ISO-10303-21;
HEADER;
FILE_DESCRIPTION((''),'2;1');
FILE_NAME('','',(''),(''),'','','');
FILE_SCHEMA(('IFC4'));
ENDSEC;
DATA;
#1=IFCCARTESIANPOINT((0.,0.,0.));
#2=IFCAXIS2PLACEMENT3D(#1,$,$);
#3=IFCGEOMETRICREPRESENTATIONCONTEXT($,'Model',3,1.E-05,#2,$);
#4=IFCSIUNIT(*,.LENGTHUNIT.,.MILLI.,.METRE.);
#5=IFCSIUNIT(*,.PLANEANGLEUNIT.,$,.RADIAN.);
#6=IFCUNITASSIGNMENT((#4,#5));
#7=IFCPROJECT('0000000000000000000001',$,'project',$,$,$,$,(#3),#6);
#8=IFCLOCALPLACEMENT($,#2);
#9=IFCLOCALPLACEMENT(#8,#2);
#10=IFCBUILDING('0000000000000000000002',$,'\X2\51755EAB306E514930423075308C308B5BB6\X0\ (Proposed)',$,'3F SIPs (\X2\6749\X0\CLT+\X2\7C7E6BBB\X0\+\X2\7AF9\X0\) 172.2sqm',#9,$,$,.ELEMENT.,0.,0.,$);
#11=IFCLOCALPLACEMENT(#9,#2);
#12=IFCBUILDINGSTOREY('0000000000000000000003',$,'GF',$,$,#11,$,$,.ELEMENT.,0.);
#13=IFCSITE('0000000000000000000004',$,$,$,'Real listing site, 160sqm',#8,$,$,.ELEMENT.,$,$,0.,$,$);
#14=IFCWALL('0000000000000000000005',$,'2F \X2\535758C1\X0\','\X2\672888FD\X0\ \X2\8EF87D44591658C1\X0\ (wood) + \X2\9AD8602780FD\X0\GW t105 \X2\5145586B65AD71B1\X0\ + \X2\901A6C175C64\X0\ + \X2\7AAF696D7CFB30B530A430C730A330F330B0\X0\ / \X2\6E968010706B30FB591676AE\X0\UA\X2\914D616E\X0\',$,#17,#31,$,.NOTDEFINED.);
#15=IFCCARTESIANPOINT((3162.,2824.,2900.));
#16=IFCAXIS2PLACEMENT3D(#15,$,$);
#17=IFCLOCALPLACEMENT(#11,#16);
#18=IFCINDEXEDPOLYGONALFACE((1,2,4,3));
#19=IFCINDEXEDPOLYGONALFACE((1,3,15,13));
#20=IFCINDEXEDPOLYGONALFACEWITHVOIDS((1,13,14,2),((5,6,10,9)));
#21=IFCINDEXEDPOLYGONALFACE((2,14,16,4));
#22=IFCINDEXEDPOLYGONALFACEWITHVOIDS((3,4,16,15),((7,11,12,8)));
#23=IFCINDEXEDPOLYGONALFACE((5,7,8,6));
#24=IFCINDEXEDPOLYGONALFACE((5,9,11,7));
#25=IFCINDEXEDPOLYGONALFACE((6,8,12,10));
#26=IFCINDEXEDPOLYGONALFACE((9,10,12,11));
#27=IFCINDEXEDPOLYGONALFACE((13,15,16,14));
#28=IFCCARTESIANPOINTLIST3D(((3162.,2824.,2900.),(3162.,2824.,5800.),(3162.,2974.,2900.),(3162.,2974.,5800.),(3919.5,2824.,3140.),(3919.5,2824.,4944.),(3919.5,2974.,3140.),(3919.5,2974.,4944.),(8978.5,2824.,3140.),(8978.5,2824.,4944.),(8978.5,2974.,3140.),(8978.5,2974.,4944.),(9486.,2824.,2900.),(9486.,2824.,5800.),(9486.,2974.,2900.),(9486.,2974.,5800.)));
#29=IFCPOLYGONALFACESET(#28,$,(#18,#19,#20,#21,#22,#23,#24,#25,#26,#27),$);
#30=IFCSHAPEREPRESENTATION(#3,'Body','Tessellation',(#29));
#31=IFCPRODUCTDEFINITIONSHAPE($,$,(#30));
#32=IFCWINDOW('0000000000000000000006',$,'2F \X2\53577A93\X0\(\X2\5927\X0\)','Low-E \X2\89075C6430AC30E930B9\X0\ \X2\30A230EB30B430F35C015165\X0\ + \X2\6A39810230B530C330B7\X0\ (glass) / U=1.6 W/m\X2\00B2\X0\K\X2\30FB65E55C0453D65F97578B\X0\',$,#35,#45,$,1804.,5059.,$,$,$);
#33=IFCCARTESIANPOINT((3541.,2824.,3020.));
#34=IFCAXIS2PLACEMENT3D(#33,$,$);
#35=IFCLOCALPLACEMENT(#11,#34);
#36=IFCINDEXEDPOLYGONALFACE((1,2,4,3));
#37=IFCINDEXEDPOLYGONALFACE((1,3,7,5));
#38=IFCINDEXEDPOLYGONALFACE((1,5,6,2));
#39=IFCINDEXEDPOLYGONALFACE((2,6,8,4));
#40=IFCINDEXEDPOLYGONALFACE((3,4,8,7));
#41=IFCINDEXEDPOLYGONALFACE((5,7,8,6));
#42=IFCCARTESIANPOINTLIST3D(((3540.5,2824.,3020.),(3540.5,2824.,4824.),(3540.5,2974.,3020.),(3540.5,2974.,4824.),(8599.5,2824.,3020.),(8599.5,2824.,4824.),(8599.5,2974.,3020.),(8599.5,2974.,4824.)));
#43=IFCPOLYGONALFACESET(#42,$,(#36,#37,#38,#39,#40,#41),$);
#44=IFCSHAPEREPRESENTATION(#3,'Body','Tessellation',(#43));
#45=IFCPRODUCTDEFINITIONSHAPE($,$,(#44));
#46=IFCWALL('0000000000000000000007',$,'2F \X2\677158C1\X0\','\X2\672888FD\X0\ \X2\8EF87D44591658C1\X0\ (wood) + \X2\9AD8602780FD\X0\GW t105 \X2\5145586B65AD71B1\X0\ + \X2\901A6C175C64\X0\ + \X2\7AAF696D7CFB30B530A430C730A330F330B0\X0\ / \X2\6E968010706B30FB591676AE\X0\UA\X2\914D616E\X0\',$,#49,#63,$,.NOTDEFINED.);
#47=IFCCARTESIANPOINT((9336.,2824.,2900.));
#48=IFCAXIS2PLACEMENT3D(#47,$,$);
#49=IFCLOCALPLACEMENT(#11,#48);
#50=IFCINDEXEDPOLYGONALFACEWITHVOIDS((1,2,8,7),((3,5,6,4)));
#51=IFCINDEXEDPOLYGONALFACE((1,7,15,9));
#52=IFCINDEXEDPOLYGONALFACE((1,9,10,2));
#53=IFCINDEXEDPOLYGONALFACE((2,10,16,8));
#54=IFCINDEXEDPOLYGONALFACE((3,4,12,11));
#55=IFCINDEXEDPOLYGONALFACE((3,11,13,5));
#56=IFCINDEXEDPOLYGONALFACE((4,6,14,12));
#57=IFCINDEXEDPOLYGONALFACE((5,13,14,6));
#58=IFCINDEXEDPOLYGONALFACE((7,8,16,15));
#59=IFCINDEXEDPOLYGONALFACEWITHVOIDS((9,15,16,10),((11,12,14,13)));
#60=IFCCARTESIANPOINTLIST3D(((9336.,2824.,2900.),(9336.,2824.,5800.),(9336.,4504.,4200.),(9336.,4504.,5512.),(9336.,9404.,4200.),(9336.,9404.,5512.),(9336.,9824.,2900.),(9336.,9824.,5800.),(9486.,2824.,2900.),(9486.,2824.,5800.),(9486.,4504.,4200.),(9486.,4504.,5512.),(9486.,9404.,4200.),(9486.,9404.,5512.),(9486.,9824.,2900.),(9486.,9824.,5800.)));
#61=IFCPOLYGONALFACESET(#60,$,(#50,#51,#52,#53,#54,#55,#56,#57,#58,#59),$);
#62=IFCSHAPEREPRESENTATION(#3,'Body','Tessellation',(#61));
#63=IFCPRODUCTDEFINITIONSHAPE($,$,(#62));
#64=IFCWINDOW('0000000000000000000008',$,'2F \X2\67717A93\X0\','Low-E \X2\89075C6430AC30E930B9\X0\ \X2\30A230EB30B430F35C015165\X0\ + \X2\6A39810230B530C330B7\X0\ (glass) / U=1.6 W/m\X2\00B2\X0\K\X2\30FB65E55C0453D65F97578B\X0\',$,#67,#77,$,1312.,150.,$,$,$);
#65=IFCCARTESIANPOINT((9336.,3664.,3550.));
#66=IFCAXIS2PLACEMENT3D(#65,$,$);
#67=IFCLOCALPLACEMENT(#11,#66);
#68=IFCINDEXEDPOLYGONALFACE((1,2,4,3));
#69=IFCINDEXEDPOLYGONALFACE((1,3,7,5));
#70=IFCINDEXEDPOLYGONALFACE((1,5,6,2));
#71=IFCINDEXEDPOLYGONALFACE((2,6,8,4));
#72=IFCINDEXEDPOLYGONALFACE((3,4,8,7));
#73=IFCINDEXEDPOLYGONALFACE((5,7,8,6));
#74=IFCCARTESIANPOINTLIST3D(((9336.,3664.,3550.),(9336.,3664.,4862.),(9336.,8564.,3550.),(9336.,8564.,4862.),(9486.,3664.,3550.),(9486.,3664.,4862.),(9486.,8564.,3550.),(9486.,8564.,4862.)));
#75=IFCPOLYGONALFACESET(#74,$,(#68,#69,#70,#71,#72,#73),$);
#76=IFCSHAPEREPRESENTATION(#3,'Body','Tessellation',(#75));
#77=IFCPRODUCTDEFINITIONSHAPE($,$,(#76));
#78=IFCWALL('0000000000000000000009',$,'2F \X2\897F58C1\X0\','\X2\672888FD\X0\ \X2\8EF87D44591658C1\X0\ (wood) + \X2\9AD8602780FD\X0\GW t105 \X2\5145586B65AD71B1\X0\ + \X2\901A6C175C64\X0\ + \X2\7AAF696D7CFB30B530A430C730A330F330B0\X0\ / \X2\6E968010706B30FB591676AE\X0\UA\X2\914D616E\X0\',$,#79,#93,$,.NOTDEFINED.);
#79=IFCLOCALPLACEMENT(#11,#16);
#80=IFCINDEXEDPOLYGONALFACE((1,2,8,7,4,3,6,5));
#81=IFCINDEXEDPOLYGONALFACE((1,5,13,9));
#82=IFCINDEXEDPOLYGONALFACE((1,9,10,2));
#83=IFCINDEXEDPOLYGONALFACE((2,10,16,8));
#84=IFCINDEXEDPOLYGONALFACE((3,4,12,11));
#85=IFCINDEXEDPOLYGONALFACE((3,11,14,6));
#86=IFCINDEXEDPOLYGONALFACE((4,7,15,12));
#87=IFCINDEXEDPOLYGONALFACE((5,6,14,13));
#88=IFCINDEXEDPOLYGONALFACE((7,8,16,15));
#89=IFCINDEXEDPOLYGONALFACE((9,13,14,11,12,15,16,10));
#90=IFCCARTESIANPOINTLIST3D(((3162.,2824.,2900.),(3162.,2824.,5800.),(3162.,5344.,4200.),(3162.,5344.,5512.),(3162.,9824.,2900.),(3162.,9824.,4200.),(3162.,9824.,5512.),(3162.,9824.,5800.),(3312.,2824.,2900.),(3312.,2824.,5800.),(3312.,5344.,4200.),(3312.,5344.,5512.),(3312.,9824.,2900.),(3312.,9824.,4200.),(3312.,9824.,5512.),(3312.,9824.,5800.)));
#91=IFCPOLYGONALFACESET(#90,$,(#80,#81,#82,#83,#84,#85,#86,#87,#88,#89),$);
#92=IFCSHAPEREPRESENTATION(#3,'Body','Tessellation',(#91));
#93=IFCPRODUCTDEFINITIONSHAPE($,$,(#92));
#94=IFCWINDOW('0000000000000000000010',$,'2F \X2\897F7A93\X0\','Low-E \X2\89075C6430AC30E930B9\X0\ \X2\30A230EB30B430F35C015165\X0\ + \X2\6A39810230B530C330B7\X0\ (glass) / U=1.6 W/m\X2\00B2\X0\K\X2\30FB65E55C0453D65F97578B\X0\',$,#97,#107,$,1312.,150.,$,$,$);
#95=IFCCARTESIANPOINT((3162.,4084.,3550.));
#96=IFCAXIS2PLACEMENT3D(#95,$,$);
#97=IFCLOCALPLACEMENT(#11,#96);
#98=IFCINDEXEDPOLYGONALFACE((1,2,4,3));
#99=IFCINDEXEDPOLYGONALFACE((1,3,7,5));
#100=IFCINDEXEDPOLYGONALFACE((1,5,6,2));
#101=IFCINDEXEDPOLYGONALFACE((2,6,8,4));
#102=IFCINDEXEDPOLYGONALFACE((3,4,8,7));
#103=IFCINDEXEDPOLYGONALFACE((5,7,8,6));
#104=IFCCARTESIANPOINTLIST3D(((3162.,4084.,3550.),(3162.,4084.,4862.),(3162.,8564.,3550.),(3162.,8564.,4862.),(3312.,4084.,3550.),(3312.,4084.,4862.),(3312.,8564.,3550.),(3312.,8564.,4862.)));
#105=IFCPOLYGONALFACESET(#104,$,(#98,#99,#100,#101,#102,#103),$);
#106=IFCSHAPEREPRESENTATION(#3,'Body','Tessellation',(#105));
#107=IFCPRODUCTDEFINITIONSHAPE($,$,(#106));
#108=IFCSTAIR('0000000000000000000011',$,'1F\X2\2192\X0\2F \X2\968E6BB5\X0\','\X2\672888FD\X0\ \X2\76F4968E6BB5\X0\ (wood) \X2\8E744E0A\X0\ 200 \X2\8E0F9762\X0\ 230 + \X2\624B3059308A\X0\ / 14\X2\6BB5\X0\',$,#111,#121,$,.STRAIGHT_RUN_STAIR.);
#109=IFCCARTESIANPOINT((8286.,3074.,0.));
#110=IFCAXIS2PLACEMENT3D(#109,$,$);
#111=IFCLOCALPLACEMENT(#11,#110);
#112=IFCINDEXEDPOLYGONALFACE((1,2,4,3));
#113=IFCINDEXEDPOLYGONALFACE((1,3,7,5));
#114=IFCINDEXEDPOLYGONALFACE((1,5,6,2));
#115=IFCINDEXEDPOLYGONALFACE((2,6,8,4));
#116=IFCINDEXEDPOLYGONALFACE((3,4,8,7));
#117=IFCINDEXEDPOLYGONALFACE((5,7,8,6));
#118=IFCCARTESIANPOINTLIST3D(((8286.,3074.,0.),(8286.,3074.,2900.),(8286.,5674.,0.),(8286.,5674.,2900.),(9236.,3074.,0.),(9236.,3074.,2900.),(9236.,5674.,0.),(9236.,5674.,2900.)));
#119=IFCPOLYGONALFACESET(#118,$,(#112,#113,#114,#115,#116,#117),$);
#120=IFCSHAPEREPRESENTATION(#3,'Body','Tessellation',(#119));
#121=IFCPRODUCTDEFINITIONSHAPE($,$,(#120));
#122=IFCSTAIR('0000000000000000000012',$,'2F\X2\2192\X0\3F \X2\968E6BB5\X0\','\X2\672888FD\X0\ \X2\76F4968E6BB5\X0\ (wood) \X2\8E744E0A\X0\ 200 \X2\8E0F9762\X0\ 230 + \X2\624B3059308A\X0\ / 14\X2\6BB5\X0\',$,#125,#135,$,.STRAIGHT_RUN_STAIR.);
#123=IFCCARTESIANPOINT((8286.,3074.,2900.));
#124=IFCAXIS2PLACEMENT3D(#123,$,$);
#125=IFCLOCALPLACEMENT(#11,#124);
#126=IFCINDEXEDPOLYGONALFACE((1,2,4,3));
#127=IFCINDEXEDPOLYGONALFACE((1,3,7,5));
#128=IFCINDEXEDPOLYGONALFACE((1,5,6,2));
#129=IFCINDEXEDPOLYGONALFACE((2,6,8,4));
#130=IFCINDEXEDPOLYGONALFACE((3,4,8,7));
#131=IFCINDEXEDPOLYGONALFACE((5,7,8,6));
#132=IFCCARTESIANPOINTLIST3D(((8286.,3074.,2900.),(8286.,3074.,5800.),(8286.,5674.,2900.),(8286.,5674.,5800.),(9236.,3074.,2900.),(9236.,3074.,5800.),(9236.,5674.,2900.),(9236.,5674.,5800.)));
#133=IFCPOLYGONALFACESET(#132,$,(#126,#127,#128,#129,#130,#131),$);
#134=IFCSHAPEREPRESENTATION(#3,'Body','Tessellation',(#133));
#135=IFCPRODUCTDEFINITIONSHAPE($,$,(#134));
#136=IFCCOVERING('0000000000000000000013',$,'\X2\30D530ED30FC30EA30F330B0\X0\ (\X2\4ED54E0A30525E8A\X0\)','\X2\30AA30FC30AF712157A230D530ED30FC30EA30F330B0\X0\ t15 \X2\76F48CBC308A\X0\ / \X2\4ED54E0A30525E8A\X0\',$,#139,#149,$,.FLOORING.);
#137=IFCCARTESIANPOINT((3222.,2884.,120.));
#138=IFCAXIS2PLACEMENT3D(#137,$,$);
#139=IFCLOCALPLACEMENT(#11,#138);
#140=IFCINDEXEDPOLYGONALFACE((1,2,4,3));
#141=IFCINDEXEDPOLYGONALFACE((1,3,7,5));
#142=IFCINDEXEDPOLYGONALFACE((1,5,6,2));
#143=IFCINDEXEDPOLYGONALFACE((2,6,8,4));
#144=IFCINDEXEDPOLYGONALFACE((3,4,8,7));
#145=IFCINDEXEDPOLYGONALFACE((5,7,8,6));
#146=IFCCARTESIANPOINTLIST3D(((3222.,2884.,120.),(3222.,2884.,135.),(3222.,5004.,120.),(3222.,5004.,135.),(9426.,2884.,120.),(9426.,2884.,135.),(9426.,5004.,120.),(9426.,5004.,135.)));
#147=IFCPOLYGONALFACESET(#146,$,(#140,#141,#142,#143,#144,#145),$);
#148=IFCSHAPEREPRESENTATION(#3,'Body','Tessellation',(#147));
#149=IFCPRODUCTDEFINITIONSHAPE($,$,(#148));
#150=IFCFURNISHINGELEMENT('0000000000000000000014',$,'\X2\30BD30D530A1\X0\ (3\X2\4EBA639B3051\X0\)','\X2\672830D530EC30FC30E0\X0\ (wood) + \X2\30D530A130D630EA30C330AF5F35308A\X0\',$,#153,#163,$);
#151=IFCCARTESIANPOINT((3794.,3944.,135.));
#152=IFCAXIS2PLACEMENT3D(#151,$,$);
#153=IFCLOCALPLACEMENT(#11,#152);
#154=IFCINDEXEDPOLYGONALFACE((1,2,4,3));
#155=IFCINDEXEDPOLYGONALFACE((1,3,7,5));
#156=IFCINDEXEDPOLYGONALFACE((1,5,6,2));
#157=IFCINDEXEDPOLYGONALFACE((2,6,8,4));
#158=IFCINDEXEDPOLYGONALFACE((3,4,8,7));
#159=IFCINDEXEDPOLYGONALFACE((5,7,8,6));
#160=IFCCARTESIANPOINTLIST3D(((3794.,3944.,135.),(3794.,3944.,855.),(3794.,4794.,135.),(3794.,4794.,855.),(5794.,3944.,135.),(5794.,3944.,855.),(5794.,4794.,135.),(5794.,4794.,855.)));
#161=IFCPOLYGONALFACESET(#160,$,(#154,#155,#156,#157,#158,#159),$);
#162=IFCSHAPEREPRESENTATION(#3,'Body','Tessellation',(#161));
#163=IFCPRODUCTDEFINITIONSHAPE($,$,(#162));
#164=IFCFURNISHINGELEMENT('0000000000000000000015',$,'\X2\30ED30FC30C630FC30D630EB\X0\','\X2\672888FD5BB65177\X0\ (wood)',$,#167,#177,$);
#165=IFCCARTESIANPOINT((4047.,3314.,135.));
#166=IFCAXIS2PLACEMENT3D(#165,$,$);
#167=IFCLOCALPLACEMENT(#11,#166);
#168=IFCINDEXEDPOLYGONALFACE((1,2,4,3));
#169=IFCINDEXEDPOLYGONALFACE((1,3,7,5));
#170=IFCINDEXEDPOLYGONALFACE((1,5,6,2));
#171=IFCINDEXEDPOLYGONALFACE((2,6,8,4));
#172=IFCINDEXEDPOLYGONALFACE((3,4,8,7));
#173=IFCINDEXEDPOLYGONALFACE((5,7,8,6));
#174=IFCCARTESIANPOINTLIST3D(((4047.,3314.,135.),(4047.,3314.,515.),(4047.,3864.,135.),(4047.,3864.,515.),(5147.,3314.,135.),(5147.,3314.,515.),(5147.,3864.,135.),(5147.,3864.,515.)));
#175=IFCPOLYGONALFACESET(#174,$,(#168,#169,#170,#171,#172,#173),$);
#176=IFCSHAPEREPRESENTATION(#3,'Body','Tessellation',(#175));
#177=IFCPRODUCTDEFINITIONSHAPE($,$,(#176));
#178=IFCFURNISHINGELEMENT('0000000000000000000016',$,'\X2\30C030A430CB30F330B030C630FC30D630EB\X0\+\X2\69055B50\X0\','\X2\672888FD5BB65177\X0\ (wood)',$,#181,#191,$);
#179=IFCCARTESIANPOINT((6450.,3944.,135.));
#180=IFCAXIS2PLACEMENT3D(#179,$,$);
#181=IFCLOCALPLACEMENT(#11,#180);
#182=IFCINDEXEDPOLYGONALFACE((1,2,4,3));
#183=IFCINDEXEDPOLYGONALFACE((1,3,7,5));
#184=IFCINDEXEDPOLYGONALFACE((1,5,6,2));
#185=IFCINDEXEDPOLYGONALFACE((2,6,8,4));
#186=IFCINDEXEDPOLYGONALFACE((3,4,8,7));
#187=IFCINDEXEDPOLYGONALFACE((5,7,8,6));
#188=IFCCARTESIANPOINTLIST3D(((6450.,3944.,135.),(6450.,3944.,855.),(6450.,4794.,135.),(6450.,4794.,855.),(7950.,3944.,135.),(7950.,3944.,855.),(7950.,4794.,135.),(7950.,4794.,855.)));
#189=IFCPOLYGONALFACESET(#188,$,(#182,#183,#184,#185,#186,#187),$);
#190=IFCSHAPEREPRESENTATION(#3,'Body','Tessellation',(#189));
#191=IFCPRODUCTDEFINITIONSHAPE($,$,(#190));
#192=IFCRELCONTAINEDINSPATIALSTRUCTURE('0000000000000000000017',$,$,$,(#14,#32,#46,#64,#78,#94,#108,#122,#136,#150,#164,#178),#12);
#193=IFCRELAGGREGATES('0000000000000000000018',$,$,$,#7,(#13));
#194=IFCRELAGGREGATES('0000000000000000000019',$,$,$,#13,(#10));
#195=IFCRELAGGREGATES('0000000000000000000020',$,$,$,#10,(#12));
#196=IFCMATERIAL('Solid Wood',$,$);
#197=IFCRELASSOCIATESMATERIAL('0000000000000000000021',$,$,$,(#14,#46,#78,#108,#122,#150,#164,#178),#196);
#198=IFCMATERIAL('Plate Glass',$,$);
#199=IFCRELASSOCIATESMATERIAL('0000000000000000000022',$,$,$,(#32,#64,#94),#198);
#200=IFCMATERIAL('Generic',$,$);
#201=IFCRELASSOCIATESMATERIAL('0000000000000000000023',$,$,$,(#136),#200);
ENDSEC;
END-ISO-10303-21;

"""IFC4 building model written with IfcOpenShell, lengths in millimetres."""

from ifc_helpers import new_model, si_unit, frame, frame_2d, origin, place, context, project, spatial, rectangle, extrude, material, element, fill, save


model = new_model("IFC4")

# Units and contexts
model_context = context("Model", 3, precision=1e-05, world=origin())
ifc_project = project(units=[si_unit("LENGTHUNIT", "METRE", prefix="MILLI"), si_unit("PLANEANGLEUNIT", "RADIAN")], contexts=[model_context])

# Site, building, storey
site_placement = place(None, origin())
site = spatial("IfcSite", under=ifc_project, at=site_placement, ObjectType="Real listing site, 160sqm", CompositionType="ELEMENT", RefElevation=0.0)
building_placement = place(site_placement, origin())
building = spatial("IfcBuilding", under=site, at=building_placement, Name="兵庫の光あふれる家 (Proposed)", ObjectType="3F SIPs (杉CLT+籾殻+竹) 172.2sqm", CompositionType="ELEMENT", ElevationOfRefHeight=0.0, ElevationOfTerrain=0.0)
storey_placement = place(building_placement, origin())
storey = spatial("IfcBuildingStorey", under=building, at=storey_placement, Name="GF", CompositionType="ELEMENT", Elevation=0.0)

# Shared definitions
ifc_material_1 = material(Name="Solid Wood")
ifc_material_2 = material(Name="Generic")

# Shared definitions
ifc_material_3 = material(Name="Plate Glass")

# Walls, openings, windows
wall_1_placement = place(storey_placement, frame((3162.0, 2824.0, 2900.0)))
wall_1 = element("IfcWall", 1, at=wall_1_placement, inside=storey, material=ifc_material_1, Name="2F 南壁", Description="木製 軸組外壁 (wood) + 高性能GW t105 充填断熱 + 通気層 + 窯業系サイディング / 準耐火・外皮UA配慮", PredefinedType="NOTDEFINED", context=model_context, shape_type="SweptSolid", body=[
    extrude(rectangle(XDim=6324.0, YDim=150.0, at=frame_2d((3162.0, 75.0))), frame((3162.0, 2824.0, 2900.0)), (0.0, 0.0, 1.0), 2900.0),
])
opening_1_placement = place(storey_placement, frame((3541.0, 2824.0, 3020.0)))
opening_1 = element("IfcOpeningElement", 2, at=opening_1_placement, cuts=wall_1, PredefinedType="NOTDEFINED", context=model_context, shape_type="SweptSolid", body=[
    extrude(rectangle(XDim=5059.0, YDim=150.0, at=frame_2d((2529.0, 75.0))), frame((3541.0, 2824.0, 3020.0)), (0.0, 0.0, 1.0), 1804.0),
])
window_1_placement = place(storey_placement, frame((3541.0, 2824.0, 3020.0)))
window_1 = element("IfcWindow", 3, at=window_1_placement, inside=storey, material=ifc_material_3, Name="2F 南窓(大)", Description="Low-E 複層ガラス アルゴン封入 + 樹脂サッシ (glass) / U=1.6 W/m²K・日射取得型", OverallHeight=1804.0, OverallWidth=5059.0, context=model_context, shape_type="SweptSolid", body=[
    extrude(rectangle(XDim=5059.0, YDim=150.0, at=frame_2d((2529.0, 75.0))), frame((3541.0, 2824.0, 3020.0)), (0.0, 0.0, 1.0), 1804.0),
])
fill(opening_1, window_1)
wall_2_placement = place(storey_placement, frame((9336.0, 2824.0, 2900.0)))
wall_2 = element("IfcWall", 4, at=wall_2_placement, inside=storey, material=ifc_material_1, Name="2F 東壁", Description="木製 軸組外壁 (wood) + 高性能GW t105 充填断熱 + 通気層 + 窯業系サイディング / 準耐火・外皮UA配慮", PredefinedType="NOTDEFINED", context=model_context, shape_type="SweptSolid", body=[
    extrude(rectangle(XDim=150.0, YDim=7000.0, at=frame_2d((75.0, 3500.0))), frame((9336.0, 2824.0, 2900.0)), (0.0, 0.0, 1.0), 2900.0),
])
opening_2_placement = place(storey_placement, frame((9336.0, 3664.0, 3550.0)))
opening_2 = element("IfcOpeningElement", 5, at=opening_2_placement, cuts=wall_2, PredefinedType="NOTDEFINED", context=model_context, shape_type="SweptSolid", body=[
    extrude(rectangle(XDim=150.0, YDim=4900.0, at=frame_2d((75.0, 2450.0))), frame((9336.0, 3664.0, 3550.0)), (0.0, 0.0, 1.0), 1312.0),
])
window_2_placement = place(storey_placement, frame((9336.0, 3664.0, 3550.0)))
window_2 = element("IfcWindow", 6, at=window_2_placement, inside=storey, material=ifc_material_3, Name="2F 東窓", Description="Low-E 複層ガラス アルゴン封入 + 樹脂サッシ (glass) / U=1.6 W/m²K・日射取得型", OverallHeight=1312.0, OverallWidth=150.0, context=model_context, shape_type="SweptSolid", body=[
    extrude(rectangle(XDim=150.0, YDim=4900.0, at=frame_2d((75.0, 2450.0))), frame((9336.0, 3664.0, 3550.0)), (0.0, 0.0, 1.0), 1312.0),
])
fill(opening_2, window_2)
wall_3_placement = place(storey_placement, frame((3162.0, 2824.0, 2900.0)))
wall_3 = element("IfcWall", 7, at=wall_3_placement, inside=storey, material=ifc_material_1, Name="2F 西壁", Description="木製 軸組外壁 (wood) + 高性能GW t105 充填断熱 + 通気層 + 窯業系サイディング / 準耐火・外皮UA配慮", PredefinedType="NOTDEFINED", context=model_context, shape_type="SweptSolid", body=[
    extrude(rectangle(XDim=150.0, YDim=7000.0, at=frame_2d((75.0, 3500.0))), frame((3162.0, 2824.0, 2900.0)), (0.0, 0.0, 1.0), 2900.0),
])
opening_3_placement = place(storey_placement, frame((3162.0, 4084.0, 3550.0)))
opening_3 = element("IfcOpeningElement", 8, at=opening_3_placement, cuts=wall_3, PredefinedType="NOTDEFINED", context=model_context, shape_type="SweptSolid", body=[
    extrude(rectangle(XDim=150.0, YDim=4480.0, at=frame_2d((75.0, 2240.0))), frame((3162.0, 4084.0, 3550.0)), (0.0, 0.0, 1.0), 1312.0),
])
window_3_placement = place(storey_placement, frame((3162.0, 4084.0, 3550.0)))
window_3 = element("IfcWindow", 9, at=window_3_placement, inside=storey, material=ifc_material_3, Name="2F 西窓", Description="Low-E 複層ガラス アルゴン封入 + 樹脂サッシ (glass) / U=1.6 W/m²K・日射取得型", OverallHeight=1312.0, OverallWidth=150.0, context=model_context, shape_type="SweptSolid", body=[
    extrude(rectangle(XDim=150.0, YDim=4480.0, at=frame_2d((75.0, 2240.0))), frame((3162.0, 4084.0, 3550.0)), (0.0, 0.0, 1.0), 1312.0),
])
fill(opening_3, window_3)

# Stairs
stair_1_placement = place(storey_placement, frame((8286.0, 3074.0, 0.0)))
element("IfcStair", 10, at=stair_1_placement, inside=storey, material=ifc_material_1, Name="1F→2F 階段", Description="木製 直階段 (wood) 蹴上 200 踏面 230 + 手すり / 14段", PredefinedType="STRAIGHT_RUN_STAIR", context=model_context, shape_type="SweptSolid", body=[
    extrude(rectangle(XDim=950.0, YDim=2600.0, at=frame_2d((475.0, 1300.0))), frame((8286.0, 3074.0, 0.0)), (0.0, 0.0, 1.0), 2900.0),
])
stair_2_placement = place(storey_placement, frame((8286.0, 3074.0, 2900.0)))
element("IfcStair", 11, at=stair_2_placement, inside=storey, material=ifc_material_1, Name="2F→3F 階段", Description="木製 直階段 (wood) 蹴上 200 踏面 230 + 手すり / 14段", PredefinedType="STRAIGHT_RUN_STAIR", context=model_context, shape_type="SweptSolid", body=[
    extrude(rectangle(XDim=950.0, YDim=2600.0, at=frame_2d((475.0, 1300.0))), frame((8286.0, 3074.0, 2900.0)), (0.0, 0.0, 1.0), 2900.0),
])

# Covering
covering_placement = place(storey_placement, frame((3222.0, 2884.0, 120.0)))
element("IfcCovering", 12, at=covering_placement, inside=storey, material=ifc_material_2, Name="フローリング (仕上げ床)", Description="オーク無垢フローリング t15 直貼り / 仕上げ床", PredefinedType="FLOORING", context=model_context, shape_type="SweptSolid", body=[
    extrude(rectangle(XDim=6204.0, YDim=2120.0, at=frame_2d((3102.0, 1060.0))), frame((3222.0, 2884.0, 120.0)), (0.0, 0.0, 1.0), 15.0),
])

# Furnishing elements
furnishing_1_placement = place(storey_placement, frame((3794.0, 3944.0, 135.0)))
element("IfcFurnishingElement", 13, at=furnishing_1_placement, inside=storey, material=ifc_material_1, Name="ソファ (3人掛け)", Description="木フレーム (wood) + ファブリック張り", context=model_context, shape_type="SweptSolid", body=[
    extrude(rectangle(XDim=2000.0, YDim=850.0, at=frame_2d((1000.0, 425.0))), frame((3794.0, 3944.0, 135.0)), (0.0, 0.0, 1.0), 720.0),
])
furnishing_2_placement = place(storey_placement, frame((4047.0, 3314.0, 135.0)))
element("IfcFurnishingElement", 14, at=furnishing_2_placement, inside=storey, material=ifc_material_1, Name="ローテーブル", Description="木製家具 (wood)", context=model_context, shape_type="SweptSolid", body=[
    extrude(rectangle(XDim=1100.0, YDim=550.0, at=frame_2d((550.0, 275.0))), frame((4047.0, 3314.0, 135.0)), (0.0, 0.0, 1.0), 380.0),
])
furnishing_3_placement = place(storey_placement, frame((6450.0, 3944.0, 135.0)))
element("IfcFurnishingElement", 15, at=furnishing_3_placement, inside=storey, material=ifc_material_1, Name="ダイニングテーブル+椅子", Description="木製家具 (wood)", context=model_context, shape_type="SweptSolid", body=[
    extrude(rectangle(XDim=1500.0, YDim=850.0, at=frame_2d((750.0, 425.0))), frame((6450.0, 3944.0, 135.0)), (0.0, 0.0, 1.0), 720.0),
])

save(model, "model.ifc")
